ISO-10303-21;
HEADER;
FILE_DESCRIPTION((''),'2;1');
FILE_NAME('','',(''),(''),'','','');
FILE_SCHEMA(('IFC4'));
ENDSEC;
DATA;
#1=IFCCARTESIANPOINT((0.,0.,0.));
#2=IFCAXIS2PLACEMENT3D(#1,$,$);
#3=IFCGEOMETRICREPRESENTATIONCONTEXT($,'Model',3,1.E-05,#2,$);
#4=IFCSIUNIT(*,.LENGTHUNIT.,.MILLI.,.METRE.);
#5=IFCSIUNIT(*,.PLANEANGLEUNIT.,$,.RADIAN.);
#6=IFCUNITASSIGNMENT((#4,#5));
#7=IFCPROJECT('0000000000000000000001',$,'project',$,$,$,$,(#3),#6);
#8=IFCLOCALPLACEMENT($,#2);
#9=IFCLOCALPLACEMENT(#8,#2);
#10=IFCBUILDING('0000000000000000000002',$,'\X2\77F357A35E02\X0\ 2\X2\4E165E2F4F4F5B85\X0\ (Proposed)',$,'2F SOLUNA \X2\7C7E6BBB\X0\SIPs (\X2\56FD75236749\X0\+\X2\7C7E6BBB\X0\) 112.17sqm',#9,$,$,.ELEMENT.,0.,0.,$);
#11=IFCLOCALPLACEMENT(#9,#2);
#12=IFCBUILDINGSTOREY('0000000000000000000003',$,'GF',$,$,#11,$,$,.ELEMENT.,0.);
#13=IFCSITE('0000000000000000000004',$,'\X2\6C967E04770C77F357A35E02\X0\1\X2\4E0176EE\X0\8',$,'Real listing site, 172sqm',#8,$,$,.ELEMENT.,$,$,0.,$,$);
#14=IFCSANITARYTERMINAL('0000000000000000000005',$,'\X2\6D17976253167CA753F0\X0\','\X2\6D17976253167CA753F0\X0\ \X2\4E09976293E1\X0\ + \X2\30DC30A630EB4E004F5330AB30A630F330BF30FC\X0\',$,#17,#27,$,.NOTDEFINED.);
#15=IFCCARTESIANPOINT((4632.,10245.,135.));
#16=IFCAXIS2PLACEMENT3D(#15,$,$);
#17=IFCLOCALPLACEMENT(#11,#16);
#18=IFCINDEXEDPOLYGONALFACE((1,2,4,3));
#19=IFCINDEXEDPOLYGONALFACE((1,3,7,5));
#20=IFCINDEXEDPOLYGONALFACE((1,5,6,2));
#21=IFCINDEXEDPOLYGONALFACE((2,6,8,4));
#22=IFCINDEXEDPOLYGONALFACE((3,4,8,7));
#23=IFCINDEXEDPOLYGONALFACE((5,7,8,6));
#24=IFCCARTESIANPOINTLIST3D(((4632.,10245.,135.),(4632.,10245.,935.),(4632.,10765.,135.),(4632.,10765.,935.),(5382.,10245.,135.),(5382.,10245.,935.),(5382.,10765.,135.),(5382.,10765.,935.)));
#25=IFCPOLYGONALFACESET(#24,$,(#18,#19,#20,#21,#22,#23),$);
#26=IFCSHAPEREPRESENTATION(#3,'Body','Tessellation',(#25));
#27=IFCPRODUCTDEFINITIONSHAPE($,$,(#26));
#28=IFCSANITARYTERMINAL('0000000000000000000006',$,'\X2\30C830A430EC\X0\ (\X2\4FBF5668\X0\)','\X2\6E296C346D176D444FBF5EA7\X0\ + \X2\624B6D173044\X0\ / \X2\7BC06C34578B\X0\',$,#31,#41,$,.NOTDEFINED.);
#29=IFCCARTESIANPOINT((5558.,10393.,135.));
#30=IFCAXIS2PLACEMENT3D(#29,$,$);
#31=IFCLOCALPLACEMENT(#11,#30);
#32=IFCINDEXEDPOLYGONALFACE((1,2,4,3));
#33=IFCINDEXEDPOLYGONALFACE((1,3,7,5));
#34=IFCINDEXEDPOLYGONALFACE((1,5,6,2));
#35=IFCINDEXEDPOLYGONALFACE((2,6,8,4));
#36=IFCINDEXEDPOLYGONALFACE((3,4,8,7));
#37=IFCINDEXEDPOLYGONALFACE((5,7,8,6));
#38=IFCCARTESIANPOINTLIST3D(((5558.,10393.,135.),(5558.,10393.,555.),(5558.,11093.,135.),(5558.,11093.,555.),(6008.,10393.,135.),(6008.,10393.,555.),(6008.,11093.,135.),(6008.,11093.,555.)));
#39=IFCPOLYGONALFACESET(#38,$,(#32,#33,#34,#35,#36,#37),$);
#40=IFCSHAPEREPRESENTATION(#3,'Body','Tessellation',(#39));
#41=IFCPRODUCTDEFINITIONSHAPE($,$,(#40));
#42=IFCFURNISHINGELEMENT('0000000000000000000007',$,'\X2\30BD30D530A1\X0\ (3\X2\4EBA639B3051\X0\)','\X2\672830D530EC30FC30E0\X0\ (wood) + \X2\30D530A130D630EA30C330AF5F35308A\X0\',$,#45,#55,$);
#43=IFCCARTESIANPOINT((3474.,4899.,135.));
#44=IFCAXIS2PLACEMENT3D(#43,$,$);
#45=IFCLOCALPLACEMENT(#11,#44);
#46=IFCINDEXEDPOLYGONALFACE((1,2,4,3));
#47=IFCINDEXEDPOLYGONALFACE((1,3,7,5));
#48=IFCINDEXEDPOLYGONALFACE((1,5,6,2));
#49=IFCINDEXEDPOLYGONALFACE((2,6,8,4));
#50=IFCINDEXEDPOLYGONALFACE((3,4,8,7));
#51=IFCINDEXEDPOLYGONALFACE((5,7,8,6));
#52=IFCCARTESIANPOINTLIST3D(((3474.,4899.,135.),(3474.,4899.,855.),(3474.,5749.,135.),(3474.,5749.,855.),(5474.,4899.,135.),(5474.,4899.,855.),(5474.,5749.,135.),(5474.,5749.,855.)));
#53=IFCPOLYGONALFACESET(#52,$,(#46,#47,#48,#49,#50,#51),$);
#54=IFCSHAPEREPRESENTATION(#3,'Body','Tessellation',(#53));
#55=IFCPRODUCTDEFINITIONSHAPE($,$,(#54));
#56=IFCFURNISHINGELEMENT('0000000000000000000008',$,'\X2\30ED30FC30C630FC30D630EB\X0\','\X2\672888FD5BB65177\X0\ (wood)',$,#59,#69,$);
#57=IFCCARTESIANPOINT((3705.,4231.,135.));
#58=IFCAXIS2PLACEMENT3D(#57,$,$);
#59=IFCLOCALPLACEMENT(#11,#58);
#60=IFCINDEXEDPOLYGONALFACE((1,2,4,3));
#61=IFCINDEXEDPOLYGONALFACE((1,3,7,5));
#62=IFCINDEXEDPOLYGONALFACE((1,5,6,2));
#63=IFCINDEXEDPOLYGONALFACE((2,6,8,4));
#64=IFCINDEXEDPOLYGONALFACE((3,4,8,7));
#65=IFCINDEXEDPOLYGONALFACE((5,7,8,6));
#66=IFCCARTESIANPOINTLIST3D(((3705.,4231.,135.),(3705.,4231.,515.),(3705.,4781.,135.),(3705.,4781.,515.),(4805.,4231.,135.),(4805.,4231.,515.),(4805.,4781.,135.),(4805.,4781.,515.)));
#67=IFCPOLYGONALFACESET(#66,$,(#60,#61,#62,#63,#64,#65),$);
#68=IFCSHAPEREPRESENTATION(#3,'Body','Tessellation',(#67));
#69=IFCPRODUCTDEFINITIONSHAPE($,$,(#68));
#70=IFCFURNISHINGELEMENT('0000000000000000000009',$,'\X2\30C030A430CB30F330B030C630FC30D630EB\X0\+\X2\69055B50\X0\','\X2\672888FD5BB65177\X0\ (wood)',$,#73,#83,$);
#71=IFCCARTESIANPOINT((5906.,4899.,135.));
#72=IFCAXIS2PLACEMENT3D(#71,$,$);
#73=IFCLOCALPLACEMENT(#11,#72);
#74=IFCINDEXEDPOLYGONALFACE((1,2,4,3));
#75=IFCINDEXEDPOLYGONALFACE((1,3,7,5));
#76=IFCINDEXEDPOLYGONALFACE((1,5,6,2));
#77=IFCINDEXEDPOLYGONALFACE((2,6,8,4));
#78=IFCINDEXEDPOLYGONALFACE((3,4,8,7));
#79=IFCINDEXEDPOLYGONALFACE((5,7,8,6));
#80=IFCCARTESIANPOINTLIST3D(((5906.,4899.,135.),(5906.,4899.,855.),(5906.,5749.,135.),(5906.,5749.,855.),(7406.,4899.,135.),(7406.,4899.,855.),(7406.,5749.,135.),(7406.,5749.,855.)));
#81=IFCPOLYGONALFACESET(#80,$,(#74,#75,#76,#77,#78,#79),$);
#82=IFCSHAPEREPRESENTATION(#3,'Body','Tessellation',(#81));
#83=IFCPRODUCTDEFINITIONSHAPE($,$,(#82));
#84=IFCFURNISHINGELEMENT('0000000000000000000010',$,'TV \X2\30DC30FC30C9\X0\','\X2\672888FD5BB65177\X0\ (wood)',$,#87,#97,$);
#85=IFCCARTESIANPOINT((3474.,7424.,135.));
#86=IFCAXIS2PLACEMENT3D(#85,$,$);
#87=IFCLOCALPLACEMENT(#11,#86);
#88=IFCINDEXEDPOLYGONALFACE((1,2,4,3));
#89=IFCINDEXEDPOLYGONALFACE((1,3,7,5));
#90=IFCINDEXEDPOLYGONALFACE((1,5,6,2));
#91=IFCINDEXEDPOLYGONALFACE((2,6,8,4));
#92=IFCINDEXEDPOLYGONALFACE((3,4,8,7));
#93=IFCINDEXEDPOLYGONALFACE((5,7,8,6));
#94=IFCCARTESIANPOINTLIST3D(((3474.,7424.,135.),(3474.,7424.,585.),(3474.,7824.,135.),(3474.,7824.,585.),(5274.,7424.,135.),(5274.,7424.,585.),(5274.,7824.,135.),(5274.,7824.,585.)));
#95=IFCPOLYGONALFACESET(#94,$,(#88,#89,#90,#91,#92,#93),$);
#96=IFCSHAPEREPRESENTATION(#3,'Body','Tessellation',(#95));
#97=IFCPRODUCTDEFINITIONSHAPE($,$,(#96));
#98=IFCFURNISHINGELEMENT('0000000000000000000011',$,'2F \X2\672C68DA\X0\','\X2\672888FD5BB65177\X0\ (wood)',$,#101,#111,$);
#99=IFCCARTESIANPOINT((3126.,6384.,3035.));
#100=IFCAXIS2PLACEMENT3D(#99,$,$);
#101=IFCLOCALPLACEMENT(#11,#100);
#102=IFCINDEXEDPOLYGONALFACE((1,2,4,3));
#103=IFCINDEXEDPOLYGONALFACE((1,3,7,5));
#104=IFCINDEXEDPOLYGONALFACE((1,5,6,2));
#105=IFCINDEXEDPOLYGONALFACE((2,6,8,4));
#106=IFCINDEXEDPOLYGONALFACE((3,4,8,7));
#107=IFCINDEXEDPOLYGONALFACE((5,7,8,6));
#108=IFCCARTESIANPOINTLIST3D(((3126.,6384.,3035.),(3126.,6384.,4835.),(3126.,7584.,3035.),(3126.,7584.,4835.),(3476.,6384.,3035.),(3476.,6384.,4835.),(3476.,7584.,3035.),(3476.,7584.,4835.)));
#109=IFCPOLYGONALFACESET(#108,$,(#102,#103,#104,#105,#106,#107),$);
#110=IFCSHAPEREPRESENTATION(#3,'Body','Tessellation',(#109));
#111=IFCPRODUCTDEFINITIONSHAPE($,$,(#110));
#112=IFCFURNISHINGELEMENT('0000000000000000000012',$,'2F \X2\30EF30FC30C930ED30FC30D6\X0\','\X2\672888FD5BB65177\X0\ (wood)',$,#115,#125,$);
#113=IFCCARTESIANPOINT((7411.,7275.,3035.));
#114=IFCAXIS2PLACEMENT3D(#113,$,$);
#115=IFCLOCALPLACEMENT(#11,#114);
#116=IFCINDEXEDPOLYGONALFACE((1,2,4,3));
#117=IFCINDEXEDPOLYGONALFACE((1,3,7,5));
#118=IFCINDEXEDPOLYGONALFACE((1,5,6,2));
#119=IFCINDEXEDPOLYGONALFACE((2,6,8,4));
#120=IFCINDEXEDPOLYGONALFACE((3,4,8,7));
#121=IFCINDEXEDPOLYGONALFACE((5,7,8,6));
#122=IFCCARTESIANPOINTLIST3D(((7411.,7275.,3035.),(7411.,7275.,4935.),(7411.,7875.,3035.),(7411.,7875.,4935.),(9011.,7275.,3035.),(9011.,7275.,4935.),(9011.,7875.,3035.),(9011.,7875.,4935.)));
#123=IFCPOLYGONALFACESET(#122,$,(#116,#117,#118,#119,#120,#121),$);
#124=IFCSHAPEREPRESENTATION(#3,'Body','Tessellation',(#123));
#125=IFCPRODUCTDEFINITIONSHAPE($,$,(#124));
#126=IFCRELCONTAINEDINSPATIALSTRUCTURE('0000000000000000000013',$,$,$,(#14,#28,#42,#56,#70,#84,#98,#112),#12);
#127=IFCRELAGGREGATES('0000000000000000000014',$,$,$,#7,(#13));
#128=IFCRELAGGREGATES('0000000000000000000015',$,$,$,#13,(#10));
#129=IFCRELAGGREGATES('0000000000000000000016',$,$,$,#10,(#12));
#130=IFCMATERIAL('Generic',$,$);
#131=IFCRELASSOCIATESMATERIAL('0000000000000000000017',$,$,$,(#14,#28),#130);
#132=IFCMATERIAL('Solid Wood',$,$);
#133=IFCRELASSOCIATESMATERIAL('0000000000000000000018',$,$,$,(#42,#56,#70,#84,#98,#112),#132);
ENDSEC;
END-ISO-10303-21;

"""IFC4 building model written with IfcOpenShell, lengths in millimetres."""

from ifc_helpers import new_model, si_unit, frame, frame_2d, origin, place, context, project, spatial, rectangle, extrude, material, element, save


model = new_model("IFC4")

# Units and contexts
model_context = context("Model", 3, precision=1e-05, world=origin())
ifc_project = project(units=[si_unit("LENGTHUNIT", "METRE", prefix="MILLI"), si_unit("PLANEANGLEUNIT", "RADIAN")], contexts=[model_context])

# Site, building, storey
site_placement = place(None, origin())
site = spatial("IfcSite", under=ifc_project, at=site_placement, Name="沖縄県石垣市1丁目8", ObjectType="Real listing site, 172sqm", CompositionType="ELEMENT", RefElevation=0.0)
building_placement = place(site_placement, origin())
building = spatial("IfcBuilding", under=site, at=building_placement, Name="石垣市 2世帯住宅 (Proposed)", ObjectType="2F SOLUNA 籾殻SIPs (国産杉+籾殻) 112.17sqm", CompositionType="ELEMENT", ElevationOfRefHeight=0.0, ElevationOfTerrain=0.0)
storey_placement = place(building_placement, origin())
storey = spatial("IfcBuildingStorey", under=building, at=storey_placement, Name="GF", CompositionType="ELEMENT", Elevation=0.0)

# Shared definitions
ifc_material_1 = material(Name="Generic")

# Shared definitions
ifc_material_2 = material(Name="Solid Wood")

# Sanitary terminals
sanitary_terminal_1_placement = place(storey_placement, frame((4632.0, 10245.0, 135.0)))
element("IfcSanitaryTerminal", 1, at=sanitary_terminal_1_placement, inside=storey, material=ifc_material_1, Name="洗面化粧台", Description="洗面化粧台 三面鏡 + ボウル一体カウンター", PredefinedType="NOTDEFINED", context=model_context, shape_type="SweptSolid", body=[
    extrude(rectangle(XDim=750.0, YDim=520.0, at=frame_2d((375.0, 260.0))), frame((4632.0, 10245.0, 135.0)), (0.0, 0.0, 1.0), 800.0),
])
sanitary_terminal_2_placement = place(storey_placement, frame((5558.0, 10393.0, 135.0)))
element("IfcSanitaryTerminal", 2, at=sanitary_terminal_2_placement, inside=storey, material=ifc_material_1, Name="トイレ (便器)", Description="温水洗浄便座 + 手洗い / 節水型", PredefinedType="NOTDEFINED", context=model_context, shape_type="SweptSolid", body=[
    extrude(rectangle(XDim=450.0, YDim=700.0, at=frame_2d((225.0, 350.0))), frame((5558.0, 10393.0, 135.0)), (0.0, 0.0, 1.0), 420.0),
])

# Furnishing elements
furnishing_1_placement = place(storey_placement, frame((3474.0, 4899.0, 135.0)))
element("IfcFurnishingElement", 3, at=furnishing_1_placement, inside=storey, material=ifc_material_2, Name="ソファ (3人掛け)", Description="木フレーム (wood) + ファブリック張り", context=model_context, shape_type="SweptSolid", body=[
    extrude(rectangle(XDim=2000.0, YDim=850.0, at=frame_2d((1000.0, 425.0))), frame((3474.0, 4899.0, 135.0)), (0.0, 0.0, 1.0), 720.0),
])
furnishing_2_placement = place(storey_placement, frame((3705.0, 4231.0, 135.0)))
element("IfcFurnishingElement", 4, at=furnishing_2_placement, inside=storey, material=ifc_material_2, Name="ローテーブル", Description="木製家具 (wood)", context=model_context, shape_type="SweptSolid", body=[
    extrude(rectangle(XDim=1100.0, YDim=550.0, at=frame_2d((550.0, 275.0))), frame((3705.0, 4231.0, 135.0)), (0.0, 0.0, 1.0), 380.0),
])
furnishing_3_placement = place(storey_placement, frame((5906.0, 4899.0, 135.0)))
element("IfcFurnishingElement", 5, at=furnishing_3_placement, inside=storey, material=ifc_material_2, Name="ダイニングテーブル+椅子", Description="木製家具 (wood)", context=model_context, shape_type="SweptSolid", body=[
    extrude(rectangle(XDim=1500.0, YDim=850.0, at=frame_2d((750.0, 425.0))), frame((5906.0, 4899.0, 135.0)), (0.0, 0.0, 1.0), 720.0),
])
furnishing_4_placement = place(storey_placement, frame((3474.0, 7424.0, 135.0)))
element("IfcFurnishingElement", 6, at=furnishing_4_placement, inside=storey, material=ifc_material_2, Name="TV ボード", Description="木製家具 (wood)", context=model_context, shape_type="SweptSolid", body=[
    extrude(rectangle(XDim=1800.0, YDim=400.0, at=frame_2d((900.0, 200.0))), frame((3474.0, 7424.0, 135.0)), (0.0, 0.0, 1.0), 450.0),
])
furnishing_5_placement = place(storey_placement, frame((3126.0, 6384.0, 3035.0)))
element("IfcFurnishingElement", 7, at=furnishing_5_placement, inside=storey, material=ifc_material_2, Name="2F 本棚", Description="木製家具 (wood)", context=model_context, shape_type="SweptSolid", body=[
    extrude(rectangle(XDim=350.0, YDim=1200.0, at=frame_2d((175.0, 600.0))), frame((3126.0, 6384.0, 3035.0)), (0.0, 0.0, 1.0), 1800.0),
])
furnishing_6_placement = place(storey_placement, frame((7411.0, 7275.0, 3035.0)))
element("IfcFurnishingElement", 8, at=furnishing_6_placement, inside=storey, material=ifc_material_2, Name="2F ワードローブ", Description="木製家具 (wood)", context=model_context, shape_type="SweptSolid", body=[
    extrude(rectangle(XDim=1600.0, YDim=600.0, at=frame_2d((800.0, 300.0))), frame((7411.0, 7275.0, 3035.0)), (0.0, 0.0, 1.0), 1900.0),
])

save(model, "model.ifc")
